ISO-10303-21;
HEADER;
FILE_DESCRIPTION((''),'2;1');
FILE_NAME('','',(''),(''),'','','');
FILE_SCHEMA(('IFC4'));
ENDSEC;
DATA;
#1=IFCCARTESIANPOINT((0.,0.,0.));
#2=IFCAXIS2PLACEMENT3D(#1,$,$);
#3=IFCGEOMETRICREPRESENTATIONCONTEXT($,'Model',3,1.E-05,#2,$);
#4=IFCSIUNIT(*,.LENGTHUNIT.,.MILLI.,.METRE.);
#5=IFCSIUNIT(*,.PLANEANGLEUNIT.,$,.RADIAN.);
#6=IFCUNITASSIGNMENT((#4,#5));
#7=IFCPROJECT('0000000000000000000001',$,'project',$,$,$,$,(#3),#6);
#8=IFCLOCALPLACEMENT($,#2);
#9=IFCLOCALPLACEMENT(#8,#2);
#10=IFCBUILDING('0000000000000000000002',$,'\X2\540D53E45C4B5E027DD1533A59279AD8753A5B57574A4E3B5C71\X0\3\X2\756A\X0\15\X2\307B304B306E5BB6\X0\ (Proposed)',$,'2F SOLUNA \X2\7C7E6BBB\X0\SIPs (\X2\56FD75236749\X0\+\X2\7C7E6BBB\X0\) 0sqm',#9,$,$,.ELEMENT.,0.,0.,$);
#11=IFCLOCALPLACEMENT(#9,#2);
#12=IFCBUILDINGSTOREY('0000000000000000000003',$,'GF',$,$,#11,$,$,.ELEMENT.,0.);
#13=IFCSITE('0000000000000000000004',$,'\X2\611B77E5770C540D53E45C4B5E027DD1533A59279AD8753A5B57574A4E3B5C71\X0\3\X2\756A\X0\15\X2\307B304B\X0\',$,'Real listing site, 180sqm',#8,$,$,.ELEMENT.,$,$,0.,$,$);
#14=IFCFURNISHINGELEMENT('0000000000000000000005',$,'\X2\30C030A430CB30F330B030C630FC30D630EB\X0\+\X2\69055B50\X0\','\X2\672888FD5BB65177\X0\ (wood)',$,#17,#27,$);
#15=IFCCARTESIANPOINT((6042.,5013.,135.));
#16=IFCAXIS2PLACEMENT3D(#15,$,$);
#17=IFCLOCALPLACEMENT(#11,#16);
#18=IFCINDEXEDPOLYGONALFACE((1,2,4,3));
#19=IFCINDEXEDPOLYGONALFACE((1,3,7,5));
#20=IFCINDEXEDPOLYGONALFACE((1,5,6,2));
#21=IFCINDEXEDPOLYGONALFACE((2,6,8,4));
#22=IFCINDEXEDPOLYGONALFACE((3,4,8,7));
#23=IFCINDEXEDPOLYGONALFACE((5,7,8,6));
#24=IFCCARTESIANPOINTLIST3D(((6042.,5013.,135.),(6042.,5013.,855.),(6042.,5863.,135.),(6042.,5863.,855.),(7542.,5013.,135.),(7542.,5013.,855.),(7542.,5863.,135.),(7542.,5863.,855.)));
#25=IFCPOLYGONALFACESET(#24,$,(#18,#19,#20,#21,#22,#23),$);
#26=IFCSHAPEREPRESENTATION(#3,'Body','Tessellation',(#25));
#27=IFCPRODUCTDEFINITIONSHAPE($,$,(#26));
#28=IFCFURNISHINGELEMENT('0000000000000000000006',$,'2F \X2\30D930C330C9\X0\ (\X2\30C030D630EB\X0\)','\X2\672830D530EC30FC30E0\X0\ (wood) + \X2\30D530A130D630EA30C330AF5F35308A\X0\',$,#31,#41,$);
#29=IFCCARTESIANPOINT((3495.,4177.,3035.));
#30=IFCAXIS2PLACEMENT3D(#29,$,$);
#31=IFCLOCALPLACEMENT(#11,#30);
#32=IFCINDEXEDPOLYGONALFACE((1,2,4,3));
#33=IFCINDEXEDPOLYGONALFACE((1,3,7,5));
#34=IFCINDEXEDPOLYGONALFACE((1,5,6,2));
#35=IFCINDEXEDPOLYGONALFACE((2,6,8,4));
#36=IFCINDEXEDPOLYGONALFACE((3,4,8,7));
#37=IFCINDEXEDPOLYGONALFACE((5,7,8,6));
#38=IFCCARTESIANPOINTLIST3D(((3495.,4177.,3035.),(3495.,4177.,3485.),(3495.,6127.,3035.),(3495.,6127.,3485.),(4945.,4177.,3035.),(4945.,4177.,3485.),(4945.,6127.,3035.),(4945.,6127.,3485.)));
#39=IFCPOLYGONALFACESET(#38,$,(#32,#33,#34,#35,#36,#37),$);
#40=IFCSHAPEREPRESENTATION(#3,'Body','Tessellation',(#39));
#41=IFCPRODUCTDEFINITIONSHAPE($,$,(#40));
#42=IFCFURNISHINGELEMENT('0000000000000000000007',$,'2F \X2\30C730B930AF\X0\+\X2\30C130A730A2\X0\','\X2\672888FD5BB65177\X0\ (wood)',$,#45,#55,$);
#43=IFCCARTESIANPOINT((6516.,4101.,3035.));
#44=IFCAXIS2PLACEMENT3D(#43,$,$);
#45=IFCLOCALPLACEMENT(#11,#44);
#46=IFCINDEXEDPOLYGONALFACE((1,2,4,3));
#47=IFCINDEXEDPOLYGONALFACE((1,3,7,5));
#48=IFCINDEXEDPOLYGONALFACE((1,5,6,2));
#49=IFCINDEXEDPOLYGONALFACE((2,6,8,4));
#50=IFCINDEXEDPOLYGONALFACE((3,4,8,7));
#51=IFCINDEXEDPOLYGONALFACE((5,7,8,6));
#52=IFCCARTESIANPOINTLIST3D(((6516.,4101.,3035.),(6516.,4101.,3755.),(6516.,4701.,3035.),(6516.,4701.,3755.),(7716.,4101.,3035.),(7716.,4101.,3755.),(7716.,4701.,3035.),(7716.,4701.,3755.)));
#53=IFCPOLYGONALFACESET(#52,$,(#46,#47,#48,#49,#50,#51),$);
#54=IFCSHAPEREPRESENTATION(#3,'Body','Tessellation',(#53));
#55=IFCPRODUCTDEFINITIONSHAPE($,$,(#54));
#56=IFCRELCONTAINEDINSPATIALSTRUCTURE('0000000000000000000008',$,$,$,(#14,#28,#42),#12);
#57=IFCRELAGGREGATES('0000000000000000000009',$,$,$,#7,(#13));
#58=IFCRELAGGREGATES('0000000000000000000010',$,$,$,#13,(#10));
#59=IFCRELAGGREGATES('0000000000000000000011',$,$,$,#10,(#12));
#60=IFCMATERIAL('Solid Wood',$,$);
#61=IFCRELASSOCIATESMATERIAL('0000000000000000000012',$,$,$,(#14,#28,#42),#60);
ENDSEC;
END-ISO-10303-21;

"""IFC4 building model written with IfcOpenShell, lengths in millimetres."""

from ifc_helpers import new_model, si_unit, frame, frame_2d, origin, place, context, project, spatial, rectangle, extrude, material, element, save


model = new_model("IFC4")

# Units and contexts
model_context = context("Model", 3, precision=1e-05, world=origin())
ifc_project = project(units=[si_unit("LENGTHUNIT", "METRE", prefix="MILLI"), si_unit("PLANEANGLEUNIT", "RADIAN")], contexts=[model_context])

# Site, building, storey
site_placement = place(None, origin())
site = spatial("IfcSite", under=ifc_project, at=site_placement, Name="愛知県名古屋市緑区大高町字坊主山3番15ほか", ObjectType="Real listing site, 180sqm", CompositionType="ELEMENT", RefElevation=0.0)
building_placement = place(site_placement, origin())
building = spatial("IfcBuilding", under=site, at=building_placement, Name="名古屋市緑区大高町字坊主山3番15ほかの家 (Proposed)", ObjectType="2F SOLUNA 籾殻SIPs (国産杉+籾殻) 0sqm", CompositionType="ELEMENT", ElevationOfRefHeight=0.0, ElevationOfTerrain=0.0)
storey_placement = place(building_placement, origin())
storey = spatial("IfcBuildingStorey", under=building, at=storey_placement, Name="GF", CompositionType="ELEMENT", Elevation=0.0)

# Shared definitions
ifc_material_1 = material(Name="Solid Wood")

# Furnishing elements
furnishing_1_placement = place(storey_placement, frame((6042.0, 5013.0, 135.0)))
element("IfcFurnishingElement", 1, at=furnishing_1_placement, inside=storey, material=ifc_material_1, Name="ダイニングテーブル+椅子", Description="木製家具 (wood)", context=model_context, shape_type="SweptSolid", body=[
    extrude(rectangle(XDim=1500.0, YDim=850.0, at=frame_2d((750.0, 425.0))), frame((6042.0, 5013.0, 135.0)), (0.0, 0.0, 1.0), 720.0),
])
furnishing_2_placement = place(storey_placement, frame((3495.0, 4177.0, 3035.0)))
element("IfcFurnishingElement", 2, at=furnishing_2_placement, inside=storey, material=ifc_material_1, Name="2F ベッド (ダブル)", Description="木フレーム (wood) + ファブリック張り", context=model_context, shape_type="SweptSolid", body=[
    extrude(rectangle(XDim=1450.0, YDim=1950.0, at=frame_2d((725.0, 975.0))), frame((3495.0, 4177.0, 3035.0)), (0.0, 0.0, 1.0), 450.0),
])
furnishing_3_placement = place(storey_placement, frame((6516.0, 4101.0, 3035.0)))
element("IfcFurnishingElement", 3, at=furnishing_3_placement, inside=storey, material=ifc_material_1, Name="2F デスク+チェア", Description="木製家具 (wood)", context=model_context, shape_type="SweptSolid", body=[
    extrude(rectangle(XDim=1200.0, YDim=600.0, at=frame_2d((600.0, 300.0))), frame((6516.0, 4101.0, 3035.0)), (0.0, 0.0, 1.0), 720.0),
])

save(model, "model.ifc")
